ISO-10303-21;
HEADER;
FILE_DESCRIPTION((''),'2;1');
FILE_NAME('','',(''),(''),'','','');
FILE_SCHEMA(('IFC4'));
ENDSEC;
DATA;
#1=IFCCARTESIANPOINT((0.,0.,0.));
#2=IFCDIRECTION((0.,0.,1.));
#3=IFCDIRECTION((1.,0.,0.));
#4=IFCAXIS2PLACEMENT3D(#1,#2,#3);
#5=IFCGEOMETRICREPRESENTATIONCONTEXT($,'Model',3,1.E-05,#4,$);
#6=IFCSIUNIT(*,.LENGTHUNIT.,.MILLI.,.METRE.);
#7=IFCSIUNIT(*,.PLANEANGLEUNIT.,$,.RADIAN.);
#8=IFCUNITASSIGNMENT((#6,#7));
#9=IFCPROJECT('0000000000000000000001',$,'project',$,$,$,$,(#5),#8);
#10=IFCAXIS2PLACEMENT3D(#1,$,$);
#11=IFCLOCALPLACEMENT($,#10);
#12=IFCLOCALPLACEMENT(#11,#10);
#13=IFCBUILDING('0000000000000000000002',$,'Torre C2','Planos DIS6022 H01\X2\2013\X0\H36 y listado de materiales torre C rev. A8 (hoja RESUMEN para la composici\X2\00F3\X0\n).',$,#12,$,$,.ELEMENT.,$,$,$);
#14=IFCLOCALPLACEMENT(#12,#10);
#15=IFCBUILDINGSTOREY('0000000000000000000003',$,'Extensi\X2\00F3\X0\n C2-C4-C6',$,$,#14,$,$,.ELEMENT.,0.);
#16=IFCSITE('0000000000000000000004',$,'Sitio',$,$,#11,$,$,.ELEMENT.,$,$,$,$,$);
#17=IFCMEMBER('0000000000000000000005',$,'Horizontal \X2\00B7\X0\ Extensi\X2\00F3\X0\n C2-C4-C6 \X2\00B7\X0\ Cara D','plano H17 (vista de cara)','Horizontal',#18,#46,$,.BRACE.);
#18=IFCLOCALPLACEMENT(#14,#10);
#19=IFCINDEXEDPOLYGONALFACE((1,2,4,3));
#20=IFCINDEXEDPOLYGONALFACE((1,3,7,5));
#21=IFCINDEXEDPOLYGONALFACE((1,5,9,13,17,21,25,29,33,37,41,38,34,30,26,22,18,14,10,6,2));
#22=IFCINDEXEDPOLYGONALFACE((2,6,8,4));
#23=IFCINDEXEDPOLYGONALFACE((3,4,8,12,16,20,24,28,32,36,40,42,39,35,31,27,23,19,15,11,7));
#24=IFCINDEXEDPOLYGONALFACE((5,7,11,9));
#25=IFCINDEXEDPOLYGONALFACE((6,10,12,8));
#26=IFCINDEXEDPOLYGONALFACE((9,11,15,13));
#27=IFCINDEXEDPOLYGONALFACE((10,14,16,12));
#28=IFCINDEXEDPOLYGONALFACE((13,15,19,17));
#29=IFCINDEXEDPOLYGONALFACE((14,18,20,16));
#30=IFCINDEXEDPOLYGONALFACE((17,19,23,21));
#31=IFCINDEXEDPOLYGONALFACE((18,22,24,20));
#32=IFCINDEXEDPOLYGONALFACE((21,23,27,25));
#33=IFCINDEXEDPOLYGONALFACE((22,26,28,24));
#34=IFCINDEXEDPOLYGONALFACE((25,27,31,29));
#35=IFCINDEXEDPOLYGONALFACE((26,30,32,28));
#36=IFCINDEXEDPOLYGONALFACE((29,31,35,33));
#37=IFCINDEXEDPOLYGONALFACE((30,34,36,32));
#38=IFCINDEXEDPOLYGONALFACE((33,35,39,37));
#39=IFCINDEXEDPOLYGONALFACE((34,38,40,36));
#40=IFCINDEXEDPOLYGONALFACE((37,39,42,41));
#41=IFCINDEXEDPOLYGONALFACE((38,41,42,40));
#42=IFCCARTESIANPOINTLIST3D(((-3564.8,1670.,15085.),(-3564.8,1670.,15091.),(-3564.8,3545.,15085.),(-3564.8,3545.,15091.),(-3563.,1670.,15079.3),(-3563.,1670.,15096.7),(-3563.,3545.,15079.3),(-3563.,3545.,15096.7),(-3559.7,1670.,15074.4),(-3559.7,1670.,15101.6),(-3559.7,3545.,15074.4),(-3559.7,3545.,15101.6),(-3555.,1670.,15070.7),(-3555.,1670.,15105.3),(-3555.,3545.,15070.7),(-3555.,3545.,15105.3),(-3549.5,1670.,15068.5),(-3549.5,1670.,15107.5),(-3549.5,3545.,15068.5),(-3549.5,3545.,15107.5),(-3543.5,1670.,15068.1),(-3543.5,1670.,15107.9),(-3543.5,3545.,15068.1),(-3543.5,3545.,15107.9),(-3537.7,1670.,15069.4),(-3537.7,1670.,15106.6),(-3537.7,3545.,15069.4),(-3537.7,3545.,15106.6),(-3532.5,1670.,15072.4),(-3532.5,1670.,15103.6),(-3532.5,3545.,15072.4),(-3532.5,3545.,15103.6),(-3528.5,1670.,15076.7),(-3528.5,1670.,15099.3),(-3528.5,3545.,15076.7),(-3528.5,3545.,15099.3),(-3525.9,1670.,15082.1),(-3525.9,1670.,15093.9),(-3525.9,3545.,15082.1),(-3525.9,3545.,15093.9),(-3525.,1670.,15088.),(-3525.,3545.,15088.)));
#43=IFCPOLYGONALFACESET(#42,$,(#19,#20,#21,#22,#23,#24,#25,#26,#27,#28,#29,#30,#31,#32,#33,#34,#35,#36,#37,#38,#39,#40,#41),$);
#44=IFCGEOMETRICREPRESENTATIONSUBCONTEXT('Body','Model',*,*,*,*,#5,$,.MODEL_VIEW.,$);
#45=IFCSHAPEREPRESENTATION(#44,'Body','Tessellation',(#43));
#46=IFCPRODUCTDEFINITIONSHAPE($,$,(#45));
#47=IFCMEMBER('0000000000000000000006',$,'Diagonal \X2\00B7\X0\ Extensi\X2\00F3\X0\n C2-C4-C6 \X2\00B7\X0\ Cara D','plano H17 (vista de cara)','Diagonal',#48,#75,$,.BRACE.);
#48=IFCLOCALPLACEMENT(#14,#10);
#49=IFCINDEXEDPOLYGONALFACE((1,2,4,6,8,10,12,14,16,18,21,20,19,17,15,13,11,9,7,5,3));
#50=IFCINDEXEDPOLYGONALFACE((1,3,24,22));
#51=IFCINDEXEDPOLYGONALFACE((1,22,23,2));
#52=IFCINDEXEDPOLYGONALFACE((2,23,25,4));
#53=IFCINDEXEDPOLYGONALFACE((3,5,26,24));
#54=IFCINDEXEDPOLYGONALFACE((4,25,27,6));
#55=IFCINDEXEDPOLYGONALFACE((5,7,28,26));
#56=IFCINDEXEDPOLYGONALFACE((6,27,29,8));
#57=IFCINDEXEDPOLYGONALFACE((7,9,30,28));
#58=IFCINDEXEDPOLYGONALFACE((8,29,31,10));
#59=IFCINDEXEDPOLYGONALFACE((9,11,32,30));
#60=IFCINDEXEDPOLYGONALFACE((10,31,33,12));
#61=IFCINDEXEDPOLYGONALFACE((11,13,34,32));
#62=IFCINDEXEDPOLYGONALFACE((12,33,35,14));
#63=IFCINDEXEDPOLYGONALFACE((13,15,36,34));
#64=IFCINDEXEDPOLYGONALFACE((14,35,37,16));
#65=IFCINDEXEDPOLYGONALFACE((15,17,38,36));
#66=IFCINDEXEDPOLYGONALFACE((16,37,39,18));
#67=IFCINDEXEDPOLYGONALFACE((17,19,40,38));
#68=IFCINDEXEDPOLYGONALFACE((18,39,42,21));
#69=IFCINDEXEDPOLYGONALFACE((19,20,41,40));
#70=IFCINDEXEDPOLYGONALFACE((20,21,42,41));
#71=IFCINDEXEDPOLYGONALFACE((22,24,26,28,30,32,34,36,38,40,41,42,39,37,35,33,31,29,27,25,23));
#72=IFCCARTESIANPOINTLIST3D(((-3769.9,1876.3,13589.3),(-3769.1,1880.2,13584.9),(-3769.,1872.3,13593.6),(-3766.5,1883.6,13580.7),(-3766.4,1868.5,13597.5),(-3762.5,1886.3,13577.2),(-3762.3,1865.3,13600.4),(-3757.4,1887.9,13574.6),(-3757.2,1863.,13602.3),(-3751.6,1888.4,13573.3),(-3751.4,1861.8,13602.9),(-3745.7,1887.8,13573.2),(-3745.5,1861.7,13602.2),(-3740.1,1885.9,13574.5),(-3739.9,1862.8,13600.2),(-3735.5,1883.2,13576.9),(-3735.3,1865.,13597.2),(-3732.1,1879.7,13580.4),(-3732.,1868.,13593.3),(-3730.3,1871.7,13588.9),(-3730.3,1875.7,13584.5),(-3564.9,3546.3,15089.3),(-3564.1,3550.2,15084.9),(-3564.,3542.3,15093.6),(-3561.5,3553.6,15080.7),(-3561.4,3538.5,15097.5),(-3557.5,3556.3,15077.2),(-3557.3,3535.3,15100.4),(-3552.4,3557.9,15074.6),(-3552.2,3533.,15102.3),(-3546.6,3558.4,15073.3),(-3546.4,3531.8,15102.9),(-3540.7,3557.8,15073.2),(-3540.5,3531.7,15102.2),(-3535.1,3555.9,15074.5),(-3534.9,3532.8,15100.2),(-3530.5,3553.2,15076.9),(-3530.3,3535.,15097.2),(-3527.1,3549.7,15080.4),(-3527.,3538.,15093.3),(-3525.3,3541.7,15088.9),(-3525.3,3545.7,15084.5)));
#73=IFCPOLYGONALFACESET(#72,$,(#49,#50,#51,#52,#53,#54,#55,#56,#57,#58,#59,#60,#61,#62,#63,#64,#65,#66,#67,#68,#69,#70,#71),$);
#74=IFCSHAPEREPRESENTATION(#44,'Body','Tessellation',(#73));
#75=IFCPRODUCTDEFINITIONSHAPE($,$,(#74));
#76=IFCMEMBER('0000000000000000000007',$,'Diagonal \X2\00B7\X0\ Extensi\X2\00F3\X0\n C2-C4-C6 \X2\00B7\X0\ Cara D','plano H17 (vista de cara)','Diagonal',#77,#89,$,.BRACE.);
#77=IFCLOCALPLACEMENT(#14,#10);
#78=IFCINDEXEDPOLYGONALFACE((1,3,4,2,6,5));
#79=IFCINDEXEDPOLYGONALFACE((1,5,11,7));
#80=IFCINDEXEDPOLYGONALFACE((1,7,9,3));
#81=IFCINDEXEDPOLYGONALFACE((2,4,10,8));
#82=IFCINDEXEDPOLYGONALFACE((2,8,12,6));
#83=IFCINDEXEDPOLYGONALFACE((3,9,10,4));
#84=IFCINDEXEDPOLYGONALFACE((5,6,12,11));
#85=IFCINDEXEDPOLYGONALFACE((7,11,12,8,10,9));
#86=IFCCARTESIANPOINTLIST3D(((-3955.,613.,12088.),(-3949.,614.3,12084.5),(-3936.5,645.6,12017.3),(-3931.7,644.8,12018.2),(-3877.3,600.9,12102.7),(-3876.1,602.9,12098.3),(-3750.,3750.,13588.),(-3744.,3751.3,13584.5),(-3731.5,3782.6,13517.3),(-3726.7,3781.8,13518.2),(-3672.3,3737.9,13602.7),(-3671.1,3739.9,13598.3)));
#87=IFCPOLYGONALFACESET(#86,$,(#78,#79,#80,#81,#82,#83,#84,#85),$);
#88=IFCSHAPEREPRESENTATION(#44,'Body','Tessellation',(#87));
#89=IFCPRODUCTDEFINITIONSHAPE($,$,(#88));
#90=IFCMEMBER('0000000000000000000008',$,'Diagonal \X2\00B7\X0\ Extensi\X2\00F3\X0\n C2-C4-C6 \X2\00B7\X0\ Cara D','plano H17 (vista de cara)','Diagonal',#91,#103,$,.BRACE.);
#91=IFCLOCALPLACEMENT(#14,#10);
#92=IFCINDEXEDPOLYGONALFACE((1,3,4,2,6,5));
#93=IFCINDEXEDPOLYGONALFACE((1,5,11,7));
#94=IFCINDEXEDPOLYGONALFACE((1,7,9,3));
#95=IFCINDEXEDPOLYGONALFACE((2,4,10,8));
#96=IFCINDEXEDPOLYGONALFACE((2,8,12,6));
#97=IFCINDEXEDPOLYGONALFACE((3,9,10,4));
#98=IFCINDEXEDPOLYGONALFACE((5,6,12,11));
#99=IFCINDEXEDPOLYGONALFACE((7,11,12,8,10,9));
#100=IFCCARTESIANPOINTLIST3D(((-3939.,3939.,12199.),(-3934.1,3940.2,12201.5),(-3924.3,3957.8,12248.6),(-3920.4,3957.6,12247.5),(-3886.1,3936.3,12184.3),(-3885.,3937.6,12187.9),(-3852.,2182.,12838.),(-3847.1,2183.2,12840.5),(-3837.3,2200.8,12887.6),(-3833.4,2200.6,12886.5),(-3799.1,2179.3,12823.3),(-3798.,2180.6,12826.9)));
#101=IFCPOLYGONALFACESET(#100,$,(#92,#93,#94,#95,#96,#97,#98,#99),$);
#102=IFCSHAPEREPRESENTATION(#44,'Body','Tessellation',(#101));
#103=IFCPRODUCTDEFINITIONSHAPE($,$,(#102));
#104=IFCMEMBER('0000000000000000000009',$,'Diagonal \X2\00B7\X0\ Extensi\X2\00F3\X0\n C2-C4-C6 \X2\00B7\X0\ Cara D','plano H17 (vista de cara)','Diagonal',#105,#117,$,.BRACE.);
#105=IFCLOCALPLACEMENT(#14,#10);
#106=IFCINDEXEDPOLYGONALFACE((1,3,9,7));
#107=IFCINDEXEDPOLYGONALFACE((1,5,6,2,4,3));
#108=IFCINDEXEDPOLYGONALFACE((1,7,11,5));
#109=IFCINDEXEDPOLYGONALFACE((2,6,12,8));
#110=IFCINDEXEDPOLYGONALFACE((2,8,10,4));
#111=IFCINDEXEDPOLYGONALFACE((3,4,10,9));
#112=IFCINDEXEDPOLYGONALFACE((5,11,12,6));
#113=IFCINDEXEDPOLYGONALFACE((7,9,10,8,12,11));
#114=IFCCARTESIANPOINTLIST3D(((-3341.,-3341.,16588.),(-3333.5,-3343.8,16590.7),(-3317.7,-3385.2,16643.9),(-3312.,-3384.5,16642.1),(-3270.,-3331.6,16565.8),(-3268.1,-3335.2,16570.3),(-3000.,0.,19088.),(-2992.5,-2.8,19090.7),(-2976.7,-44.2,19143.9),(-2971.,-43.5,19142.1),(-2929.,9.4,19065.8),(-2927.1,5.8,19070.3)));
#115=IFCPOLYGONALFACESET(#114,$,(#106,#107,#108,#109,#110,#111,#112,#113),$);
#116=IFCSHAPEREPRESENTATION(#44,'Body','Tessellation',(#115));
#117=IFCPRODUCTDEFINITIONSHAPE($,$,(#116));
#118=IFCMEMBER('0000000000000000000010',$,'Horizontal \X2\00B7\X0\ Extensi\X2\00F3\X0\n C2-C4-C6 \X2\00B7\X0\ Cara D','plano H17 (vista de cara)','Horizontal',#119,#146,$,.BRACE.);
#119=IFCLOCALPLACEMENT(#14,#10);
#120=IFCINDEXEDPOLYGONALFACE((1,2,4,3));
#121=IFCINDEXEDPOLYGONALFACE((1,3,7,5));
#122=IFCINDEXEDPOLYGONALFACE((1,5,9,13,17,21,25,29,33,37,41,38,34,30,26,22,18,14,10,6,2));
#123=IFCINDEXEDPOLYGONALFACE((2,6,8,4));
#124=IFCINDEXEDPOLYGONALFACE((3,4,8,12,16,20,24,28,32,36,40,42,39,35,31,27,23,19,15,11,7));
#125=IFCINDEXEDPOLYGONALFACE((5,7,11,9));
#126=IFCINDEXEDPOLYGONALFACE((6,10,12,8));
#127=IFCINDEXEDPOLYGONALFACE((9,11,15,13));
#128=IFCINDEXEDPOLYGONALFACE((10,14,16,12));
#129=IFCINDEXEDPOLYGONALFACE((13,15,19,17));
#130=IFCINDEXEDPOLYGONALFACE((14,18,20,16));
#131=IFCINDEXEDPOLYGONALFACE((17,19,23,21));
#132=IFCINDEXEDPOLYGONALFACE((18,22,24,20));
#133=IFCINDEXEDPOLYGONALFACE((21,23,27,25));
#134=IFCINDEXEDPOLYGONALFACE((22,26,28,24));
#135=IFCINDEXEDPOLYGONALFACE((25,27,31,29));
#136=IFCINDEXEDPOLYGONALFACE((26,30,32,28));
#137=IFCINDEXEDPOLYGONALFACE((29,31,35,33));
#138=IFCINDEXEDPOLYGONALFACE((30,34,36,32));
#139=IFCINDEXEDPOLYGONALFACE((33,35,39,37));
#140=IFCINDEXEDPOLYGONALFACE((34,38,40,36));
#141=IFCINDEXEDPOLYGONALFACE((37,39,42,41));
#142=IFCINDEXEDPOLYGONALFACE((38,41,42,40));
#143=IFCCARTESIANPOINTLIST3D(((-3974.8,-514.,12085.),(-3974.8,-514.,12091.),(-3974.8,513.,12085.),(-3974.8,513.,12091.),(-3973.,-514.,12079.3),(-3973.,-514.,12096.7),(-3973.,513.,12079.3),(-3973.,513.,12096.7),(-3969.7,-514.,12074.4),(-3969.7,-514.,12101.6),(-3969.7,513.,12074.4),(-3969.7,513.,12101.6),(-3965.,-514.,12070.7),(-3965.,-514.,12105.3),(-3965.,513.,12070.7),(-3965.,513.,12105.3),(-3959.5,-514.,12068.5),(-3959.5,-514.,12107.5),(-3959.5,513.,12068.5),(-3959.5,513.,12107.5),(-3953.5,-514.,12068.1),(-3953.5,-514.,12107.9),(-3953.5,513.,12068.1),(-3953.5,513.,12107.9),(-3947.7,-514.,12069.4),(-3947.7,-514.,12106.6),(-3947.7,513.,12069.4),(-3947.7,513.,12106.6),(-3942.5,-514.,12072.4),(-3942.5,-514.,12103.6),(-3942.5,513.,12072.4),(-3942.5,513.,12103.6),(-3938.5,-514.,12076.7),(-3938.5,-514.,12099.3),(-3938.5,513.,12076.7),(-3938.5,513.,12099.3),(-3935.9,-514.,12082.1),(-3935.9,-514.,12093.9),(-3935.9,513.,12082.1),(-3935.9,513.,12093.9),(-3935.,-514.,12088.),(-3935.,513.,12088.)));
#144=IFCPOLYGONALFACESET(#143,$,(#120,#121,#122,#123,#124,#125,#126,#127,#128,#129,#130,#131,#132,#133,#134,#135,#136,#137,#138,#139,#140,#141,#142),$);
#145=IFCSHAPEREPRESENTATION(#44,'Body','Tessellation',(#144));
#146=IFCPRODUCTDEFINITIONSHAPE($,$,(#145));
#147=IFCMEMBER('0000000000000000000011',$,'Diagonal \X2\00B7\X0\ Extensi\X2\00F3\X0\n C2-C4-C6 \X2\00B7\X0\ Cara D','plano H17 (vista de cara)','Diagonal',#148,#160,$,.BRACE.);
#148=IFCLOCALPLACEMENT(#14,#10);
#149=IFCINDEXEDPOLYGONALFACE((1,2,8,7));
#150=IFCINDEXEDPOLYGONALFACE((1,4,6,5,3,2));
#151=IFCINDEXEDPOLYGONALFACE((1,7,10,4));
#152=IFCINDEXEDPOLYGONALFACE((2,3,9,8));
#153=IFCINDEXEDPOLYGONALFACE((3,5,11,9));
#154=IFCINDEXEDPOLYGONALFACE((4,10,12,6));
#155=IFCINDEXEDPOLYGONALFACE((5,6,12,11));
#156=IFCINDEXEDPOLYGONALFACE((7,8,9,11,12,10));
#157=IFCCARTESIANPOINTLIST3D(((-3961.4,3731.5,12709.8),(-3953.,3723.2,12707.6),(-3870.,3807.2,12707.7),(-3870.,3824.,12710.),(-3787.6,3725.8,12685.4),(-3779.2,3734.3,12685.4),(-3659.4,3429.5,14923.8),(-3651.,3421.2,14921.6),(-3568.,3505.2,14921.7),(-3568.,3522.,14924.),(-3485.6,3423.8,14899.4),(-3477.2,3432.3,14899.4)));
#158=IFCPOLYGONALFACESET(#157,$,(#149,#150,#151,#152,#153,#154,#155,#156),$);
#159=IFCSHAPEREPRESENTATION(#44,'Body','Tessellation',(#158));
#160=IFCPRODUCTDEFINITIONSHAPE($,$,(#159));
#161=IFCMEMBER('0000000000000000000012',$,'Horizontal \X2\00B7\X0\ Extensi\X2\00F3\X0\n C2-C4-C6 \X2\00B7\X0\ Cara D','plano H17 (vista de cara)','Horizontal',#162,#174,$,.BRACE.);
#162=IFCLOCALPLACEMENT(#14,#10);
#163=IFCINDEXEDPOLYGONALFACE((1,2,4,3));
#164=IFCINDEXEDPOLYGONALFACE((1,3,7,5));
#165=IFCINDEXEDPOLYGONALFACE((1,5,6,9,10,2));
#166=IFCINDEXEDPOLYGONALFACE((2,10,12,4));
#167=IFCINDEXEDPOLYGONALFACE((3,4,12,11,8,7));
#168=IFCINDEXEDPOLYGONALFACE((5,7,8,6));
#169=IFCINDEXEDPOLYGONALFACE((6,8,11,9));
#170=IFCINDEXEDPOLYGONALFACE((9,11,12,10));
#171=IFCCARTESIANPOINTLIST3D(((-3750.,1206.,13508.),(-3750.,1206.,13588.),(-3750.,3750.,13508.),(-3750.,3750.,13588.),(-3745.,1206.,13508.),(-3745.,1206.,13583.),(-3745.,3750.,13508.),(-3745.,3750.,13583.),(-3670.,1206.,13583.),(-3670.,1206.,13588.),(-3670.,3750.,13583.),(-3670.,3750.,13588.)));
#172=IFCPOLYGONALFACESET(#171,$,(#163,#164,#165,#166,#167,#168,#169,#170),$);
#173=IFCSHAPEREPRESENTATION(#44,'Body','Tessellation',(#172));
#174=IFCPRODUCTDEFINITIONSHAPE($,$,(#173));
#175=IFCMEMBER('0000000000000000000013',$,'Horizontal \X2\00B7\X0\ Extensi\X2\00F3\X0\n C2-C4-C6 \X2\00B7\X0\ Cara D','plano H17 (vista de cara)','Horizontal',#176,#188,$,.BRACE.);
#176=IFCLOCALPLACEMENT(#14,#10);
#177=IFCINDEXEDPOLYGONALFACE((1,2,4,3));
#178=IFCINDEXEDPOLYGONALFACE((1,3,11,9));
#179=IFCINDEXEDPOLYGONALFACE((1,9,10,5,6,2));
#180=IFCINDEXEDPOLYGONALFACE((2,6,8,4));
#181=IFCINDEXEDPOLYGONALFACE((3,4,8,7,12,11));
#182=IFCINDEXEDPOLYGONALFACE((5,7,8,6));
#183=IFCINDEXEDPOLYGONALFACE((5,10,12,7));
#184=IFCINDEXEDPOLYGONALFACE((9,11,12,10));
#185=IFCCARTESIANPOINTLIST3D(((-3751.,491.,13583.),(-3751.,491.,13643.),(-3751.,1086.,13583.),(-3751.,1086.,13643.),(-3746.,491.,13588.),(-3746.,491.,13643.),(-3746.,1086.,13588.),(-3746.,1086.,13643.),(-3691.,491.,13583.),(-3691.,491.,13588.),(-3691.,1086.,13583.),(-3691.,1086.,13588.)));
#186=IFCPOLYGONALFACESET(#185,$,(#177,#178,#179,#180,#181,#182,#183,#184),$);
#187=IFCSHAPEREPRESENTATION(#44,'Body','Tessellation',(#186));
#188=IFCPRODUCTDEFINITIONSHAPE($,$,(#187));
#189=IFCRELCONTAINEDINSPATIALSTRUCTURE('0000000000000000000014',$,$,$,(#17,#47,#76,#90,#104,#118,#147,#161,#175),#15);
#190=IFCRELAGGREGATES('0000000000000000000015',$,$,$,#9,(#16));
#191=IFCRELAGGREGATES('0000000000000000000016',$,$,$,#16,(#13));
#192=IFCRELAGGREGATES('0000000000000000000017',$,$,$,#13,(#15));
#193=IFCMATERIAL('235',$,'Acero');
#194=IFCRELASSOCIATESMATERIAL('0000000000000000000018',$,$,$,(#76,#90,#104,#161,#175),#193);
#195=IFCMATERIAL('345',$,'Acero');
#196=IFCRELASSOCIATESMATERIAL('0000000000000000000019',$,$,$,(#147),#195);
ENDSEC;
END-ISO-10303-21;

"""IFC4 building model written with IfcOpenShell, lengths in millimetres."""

from ifc_helpers import new_model, si_unit, frame, frame_2d, origin, origin_with_axes, place, context, subcontext, project, spatial, circle, l_section, extrude, material, element, save


model = new_model("IFC4")

# Units and contexts
model_context = context("Model", 3, precision=1e-05, world=origin_with_axes())
body_context = subcontext(model_context, "Body", "Model", "MODEL_VIEW")
ifc_project = project(units=[si_unit("LENGTHUNIT", "METRE", prefix="MILLI"), si_unit("PLANEANGLEUNIT", "RADIAN")], contexts=[model_context])

# Site, building, storey
site_placement = place(None, origin())
site = spatial("IfcSite", under=ifc_project, at=site_placement, Name="Sitio", CompositionType="ELEMENT")
building_placement = place(site_placement, origin())
building = spatial("IfcBuilding", under=site, at=building_placement, Name="Torre C2", Description="Planos DIS6022 H01–H36 y listado de materiales torre C rev. A8 (hoja RESUMEN para la composición).", CompositionType="ELEMENT")
storey_placement = place(building_placement, origin())
storey = spatial("IfcBuildingStorey", under=building, at=storey_placement, Name="Extensión C2-C4-C6", CompositionType="ELEMENT", Elevation=0.0)

# Members
ifc_material_1 = material(Name="235", Category="Acero")
ifc_material_2 = material(Name="345", Category="Acero")
member_1_placement = place(storey_placement, frame((-3545.0, 1670.0, 15088.0), z_axis=(0.0, 1.0, 0.0), x_axis=(1.0, 0.0, 0.0)))
element("IfcMember", 1, at=member_1_placement, inside=storey, Name="Horizontal · Extensión C2-C4-C6 · Cara D", Description="plano H17 (vista de cara)", ObjectType="Horizontal", PredefinedType="BRACE", context=body_context, shape_type="SweptSolid", body=[
    extrude(circle(Radius=20.0), None, (0.0, 0.0, 1.0), 1875.0),
])
member_2_placement = place(storey_placement, frame((-3545.0, 3545.0, 15088.0), z_axis=(-0.090946, -0.740875, -0.665457), x_axis=(0.899679, -0.347628, 0.264069)))
element("IfcMember", 2, at=member_2_placement, inside=storey, Name="Diagonal · Extensión C2-C4-C6 · Cara D", Description="plano H17 (vista de cara)", ObjectType="Diagonal", PredefinedType="BRACE", context=body_context, shape_type="SweptSolid", body=[
    extrude(circle(Radius=20.0), None, (0.0, 0.0, 1.0), 2254.1),
])
member_3_placement = place(storey_placement, frame((-3955.0, 613.0, 12088.0), z_axis=(0.058854, 0.900604, 0.430637), x_axis=(0.971241, -0.151357, 0.183801)))
element("IfcMember", 3, at=member_3_placement, inside=storey, material=ifc_material_1, Name="Diagonal · Extensión C2-C4-C6 · Cara D", Description="plano H17 (vista de cara)", ObjectType="Diagonal", PredefinedType="BRACE", context=body_context, shape_type="SweptSolid", body=[
    extrude(l_section(Depth=80.0, Width=80.0, Thickness=5.0, at=frame_2d((40.0, 40.0))), None, (0.0, 0.0, 1.0), 3483.2),
])
member_4_placement = place(storey_placement, frame((-3939.0, 3939.0, 12199.0), z_axis=(0.046484, -0.938762, 0.341417), x_axis=(0.962327, -0.049576, -0.267337)))
element("IfcMember", 4, at=member_4_placement, inside=storey, material=ifc_material_1, Name="Diagonal · Extensión C2-C4-C6 · Cara D", Description="plano H17 (vista de cara)", ObjectType="Diagonal", PredefinedType="BRACE", context=body_context, shape_type="SweptSolid", body=[
    extrude(l_section(Depth=55.0, Width=55.0, Thickness=4.0, at=frame_2d((27.5, 27.5))), None, (0.0, 0.0, 1.0), 1871.6),
])
member_5_placement = place(storey_placement, frame((-3000.0, 0.0, 19088.0), z_axis=(-0.081448, -0.798001, -0.597127), x_axis=(0.947028, 0.124774, -0.295923)))
element("IfcMember", 5, at=member_5_placement, inside=storey, material=ifc_material_1, Name="Diagonal · Extensión C2-C4-C6 · Cara D", Description="plano H17 (vista de cara)", ObjectType="Diagonal", PredefinedType="BRACE", context=body_context, shape_type="SweptSolid", body=[
    extrude(l_section(Depth=75.0, Width=75.0, Thickness=6.0, at=frame_2d((37.5, 37.5))), None, (0.0, 0.0, 1.0), 4186.7),
])
member_6_placement = place(storey_placement, frame((-3955.0, 513.0, 12088.0), z_axis=(0.0, -1.0, 0.0), x_axis=(1.0, 0.0, 0.0)))
element("IfcMember", 6, at=member_6_placement, inside=storey, Name="Horizontal · Extensión C2-C4-C6 · Cara D", Description="plano H17 (vista de cara)", ObjectType="Horizontal", PredefinedType="BRACE", context=body_context, shape_type="SweptSolid", body=[
    extrude(circle(Radius=20.0), None, (0.0, 0.0, 1.0), 1027.0),
])
member_7_placement = place(storey_placement, frame((-3568.0, 3522.0, 14924.0), z_axis=(-0.133935, 0.133935, -0.981897), x_axis=(0.698774, -0.689811, -0.189409)))
element("IfcMember", 7, at=member_7_placement, inside=storey, material=ifc_material_2, Name="Diagonal · Extensión C2-C4-C6 · Cara D", Description="plano H17 (vista de cara)", ObjectType="Diagonal", PredefinedType="BRACE", context=body_context, shape_type="SweptSolid", body=[
    extrude(l_section(Depth=130.0, Width=130.0, Thickness=12.0, at=frame_2d((65.0, 65.0))), None, (0.0, 0.0, 1.0), 2254.8),
])
member_8_placement = place(storey_placement, frame((-3750.0, 1206.0, 13588.0), z_axis=(0.0, 1.0, 0.0), x_axis=(1.0, 0.0, 0.0)))
element("IfcMember", 8, at=member_8_placement, inside=storey, material=ifc_material_1, Name="Horizontal · Extensión C2-C4-C6 · Cara D", Description="plano H17 (vista de cara)", ObjectType="Horizontal", PredefinedType="BRACE", context=body_context, shape_type="SweptSolid", body=[
    extrude(l_section(Depth=80.0, Width=80.0, Thickness=5.0, at=frame_2d((40.0, 40.0))), None, (0.0, 0.0, 1.0), 2544.0),
])
member_9_placement = place(storey_placement, frame((-3751.0, 1086.0, 13583.0), z_axis=(0.0, -1.0, 0.0), x_axis=(1.0, 0.0, 0.0)))
element("IfcMember", 9, at=member_9_placement, inside=storey, material=ifc_material_1, Name="Horizontal · Extensión C2-C4-C6 · Cara D", Description="plano H17 (vista de cara)", ObjectType="Horizontal", PredefinedType="BRACE", context=body_context, shape_type="SweptSolid", body=[
    extrude(l_section(Depth=60.0, Width=60.0, Thickness=5.0, at=frame_2d((30.0, 30.0))), None, (0.0, 0.0, 1.0), 595.0),
])

save(model, "model.ifc")
